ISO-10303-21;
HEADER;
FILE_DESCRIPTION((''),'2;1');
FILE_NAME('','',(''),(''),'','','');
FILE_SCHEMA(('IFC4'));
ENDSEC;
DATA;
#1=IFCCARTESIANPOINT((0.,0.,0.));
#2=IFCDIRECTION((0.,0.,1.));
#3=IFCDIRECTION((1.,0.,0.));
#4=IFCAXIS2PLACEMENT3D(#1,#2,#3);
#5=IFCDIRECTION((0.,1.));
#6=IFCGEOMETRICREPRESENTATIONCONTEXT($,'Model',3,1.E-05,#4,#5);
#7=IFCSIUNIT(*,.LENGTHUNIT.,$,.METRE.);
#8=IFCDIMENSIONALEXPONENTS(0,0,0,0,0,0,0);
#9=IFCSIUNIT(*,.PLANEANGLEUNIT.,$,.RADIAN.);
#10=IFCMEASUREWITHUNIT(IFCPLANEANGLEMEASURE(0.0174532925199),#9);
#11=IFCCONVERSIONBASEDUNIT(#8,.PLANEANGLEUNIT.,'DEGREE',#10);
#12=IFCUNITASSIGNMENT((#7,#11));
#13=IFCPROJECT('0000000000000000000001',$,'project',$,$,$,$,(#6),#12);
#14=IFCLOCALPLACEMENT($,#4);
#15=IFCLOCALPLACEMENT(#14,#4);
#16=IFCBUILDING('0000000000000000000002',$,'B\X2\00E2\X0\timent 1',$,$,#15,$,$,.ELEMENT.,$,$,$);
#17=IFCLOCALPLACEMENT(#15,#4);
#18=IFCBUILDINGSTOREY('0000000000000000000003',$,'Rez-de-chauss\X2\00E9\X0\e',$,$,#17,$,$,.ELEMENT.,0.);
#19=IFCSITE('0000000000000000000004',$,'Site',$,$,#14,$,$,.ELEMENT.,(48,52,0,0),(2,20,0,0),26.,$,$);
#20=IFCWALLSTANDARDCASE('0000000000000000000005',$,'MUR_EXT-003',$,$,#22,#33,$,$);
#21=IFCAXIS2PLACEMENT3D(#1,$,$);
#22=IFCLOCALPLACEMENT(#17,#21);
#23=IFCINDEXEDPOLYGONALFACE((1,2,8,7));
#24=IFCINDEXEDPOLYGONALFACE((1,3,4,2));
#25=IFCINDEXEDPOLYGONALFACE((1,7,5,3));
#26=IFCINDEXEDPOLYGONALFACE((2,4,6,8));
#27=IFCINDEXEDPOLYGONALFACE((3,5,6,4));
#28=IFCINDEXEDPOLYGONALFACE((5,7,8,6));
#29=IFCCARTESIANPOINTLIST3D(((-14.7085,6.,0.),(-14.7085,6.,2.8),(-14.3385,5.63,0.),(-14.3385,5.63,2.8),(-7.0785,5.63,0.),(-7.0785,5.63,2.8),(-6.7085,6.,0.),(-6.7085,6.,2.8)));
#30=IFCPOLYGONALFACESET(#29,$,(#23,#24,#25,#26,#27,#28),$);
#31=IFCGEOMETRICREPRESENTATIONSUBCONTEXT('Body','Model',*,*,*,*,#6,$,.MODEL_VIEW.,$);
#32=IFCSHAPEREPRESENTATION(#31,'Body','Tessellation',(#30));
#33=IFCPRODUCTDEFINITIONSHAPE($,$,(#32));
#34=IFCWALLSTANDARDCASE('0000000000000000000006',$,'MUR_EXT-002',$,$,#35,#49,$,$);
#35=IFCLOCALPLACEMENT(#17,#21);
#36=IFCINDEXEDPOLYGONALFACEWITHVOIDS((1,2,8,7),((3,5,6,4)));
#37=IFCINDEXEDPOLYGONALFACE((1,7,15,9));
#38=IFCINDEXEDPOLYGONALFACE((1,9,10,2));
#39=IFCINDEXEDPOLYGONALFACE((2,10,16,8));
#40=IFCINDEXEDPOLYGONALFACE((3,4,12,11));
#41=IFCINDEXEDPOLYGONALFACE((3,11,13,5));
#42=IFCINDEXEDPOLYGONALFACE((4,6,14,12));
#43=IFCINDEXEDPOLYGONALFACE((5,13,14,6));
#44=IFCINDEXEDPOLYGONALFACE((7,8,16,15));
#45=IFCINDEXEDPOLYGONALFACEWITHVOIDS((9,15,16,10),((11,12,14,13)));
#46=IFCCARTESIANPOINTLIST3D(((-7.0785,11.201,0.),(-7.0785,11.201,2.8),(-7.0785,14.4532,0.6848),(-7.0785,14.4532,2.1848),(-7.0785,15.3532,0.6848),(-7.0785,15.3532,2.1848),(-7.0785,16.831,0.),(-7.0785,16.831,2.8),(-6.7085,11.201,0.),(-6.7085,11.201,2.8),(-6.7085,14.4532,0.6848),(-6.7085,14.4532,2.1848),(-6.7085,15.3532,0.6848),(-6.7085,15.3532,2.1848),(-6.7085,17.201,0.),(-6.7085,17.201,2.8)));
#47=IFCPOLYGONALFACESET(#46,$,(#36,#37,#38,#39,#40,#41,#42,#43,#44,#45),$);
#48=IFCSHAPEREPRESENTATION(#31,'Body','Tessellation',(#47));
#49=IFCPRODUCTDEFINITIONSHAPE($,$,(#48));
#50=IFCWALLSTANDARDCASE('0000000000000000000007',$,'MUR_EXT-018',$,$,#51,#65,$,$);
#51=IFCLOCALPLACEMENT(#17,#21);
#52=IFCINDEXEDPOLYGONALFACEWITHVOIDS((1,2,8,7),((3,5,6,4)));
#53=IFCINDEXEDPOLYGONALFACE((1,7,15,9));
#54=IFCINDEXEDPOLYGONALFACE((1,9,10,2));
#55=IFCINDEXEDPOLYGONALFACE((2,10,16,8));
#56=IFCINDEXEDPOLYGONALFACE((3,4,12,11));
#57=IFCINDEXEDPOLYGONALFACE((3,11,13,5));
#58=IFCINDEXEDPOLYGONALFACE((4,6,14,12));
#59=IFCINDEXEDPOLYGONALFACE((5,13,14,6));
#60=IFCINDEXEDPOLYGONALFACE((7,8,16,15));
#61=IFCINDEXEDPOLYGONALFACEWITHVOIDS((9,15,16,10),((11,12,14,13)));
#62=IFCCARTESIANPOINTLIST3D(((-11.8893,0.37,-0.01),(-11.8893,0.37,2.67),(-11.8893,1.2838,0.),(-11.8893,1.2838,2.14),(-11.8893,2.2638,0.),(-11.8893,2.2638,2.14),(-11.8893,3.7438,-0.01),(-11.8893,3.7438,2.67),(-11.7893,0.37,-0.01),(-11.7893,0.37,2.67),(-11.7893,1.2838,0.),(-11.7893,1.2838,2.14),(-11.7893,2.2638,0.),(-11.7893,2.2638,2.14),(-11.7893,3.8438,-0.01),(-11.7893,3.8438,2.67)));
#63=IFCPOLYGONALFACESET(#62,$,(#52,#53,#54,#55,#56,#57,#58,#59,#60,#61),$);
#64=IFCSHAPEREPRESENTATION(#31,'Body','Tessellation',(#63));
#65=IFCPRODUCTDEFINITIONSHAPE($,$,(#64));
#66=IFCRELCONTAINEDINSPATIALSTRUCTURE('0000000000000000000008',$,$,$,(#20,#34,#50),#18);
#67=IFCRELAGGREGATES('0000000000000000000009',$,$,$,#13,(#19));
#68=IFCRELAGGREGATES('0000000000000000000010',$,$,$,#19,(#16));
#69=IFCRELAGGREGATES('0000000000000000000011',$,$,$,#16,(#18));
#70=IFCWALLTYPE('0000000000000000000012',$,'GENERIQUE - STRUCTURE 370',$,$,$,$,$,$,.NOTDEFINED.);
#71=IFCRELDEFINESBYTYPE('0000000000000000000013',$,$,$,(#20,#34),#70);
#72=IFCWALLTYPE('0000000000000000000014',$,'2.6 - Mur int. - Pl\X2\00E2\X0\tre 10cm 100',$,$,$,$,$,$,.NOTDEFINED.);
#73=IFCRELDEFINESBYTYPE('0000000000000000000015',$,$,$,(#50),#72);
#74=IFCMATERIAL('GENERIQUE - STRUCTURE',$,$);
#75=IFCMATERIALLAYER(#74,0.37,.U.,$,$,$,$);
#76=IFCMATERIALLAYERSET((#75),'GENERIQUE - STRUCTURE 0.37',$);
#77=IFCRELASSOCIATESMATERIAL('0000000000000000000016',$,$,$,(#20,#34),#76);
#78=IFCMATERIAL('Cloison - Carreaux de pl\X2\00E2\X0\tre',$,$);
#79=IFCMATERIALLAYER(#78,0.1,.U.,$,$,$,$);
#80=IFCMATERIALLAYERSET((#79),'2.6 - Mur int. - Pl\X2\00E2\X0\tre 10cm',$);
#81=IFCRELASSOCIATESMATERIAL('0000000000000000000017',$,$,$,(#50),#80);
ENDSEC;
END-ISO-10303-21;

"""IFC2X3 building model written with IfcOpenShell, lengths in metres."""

from ifc_helpers import new_model, entity, si_unit, converted_unit, direction, frame, origin_with_axes, origin_2d_with_axis, place, context, subcontext, project, spatial, polyline, rectangle, outline, extrude, material, layer, layer_set, layer_usage, type_object, element, save


model = new_model("IFC2X3")

# Units and contexts
model_context = context("Model", 3, precision=1e-05, world=origin_with_axes(), true_north=direction((0.0, 1.0)))
body_context = subcontext(model_context, "Body", "Model", "MODEL_VIEW")
ifc_project = project(units=[si_unit("LENGTHUNIT", "METRE"), converted_unit("PLANEANGLEUNIT", "DEGREE", entity("IfcPlaneAngleMeasure", 0.0174532925199), si_unit("PLANEANGLEUNIT", "RADIAN"), dimensions=[0, 0, 0, 0, 0, 0, 0])], contexts=[model_context])

# Site, building, storey
site_placement = place(None, origin_with_axes())
site = spatial("IfcSite", under=ifc_project, at=site_placement, Name="Site", CompositionType="ELEMENT", RefLatitude=(48, 52, 0, 0), RefLongitude=(2, 20, 0, 0), RefElevation=26.0)
building_placement = place(site_placement, origin_with_axes())
building = spatial("IfcBuilding", under=site, at=building_placement, Name="Bâtiment 1", CompositionType="ELEMENT")
storey_placement = place(building_placement, origin_with_axes())
storey = spatial("IfcBuildingStorey", under=building, at=storey_placement, Name="Rez-de-chaussée", CompositionType="ELEMENT", Elevation=0.0)

# Shared definitions
ifc_material_1 = material(Name="GENERIQUE - STRUCTURE")
ifc_layer_1 = layer(ifc_material_1, 0.37, ventilated="UNKNOWN")
ifc_layer_set_1 = layer_set([ifc_layer_1], Name="GENERIQUE - STRUCTURE 0.37")
wall_type_1 = type_object("IfcWallType", Name="GENERIQUE - STRUCTURE 370", PredefinedType="NOTDEFINED")

# Wall
ifc_layer_usage_1 = layer_usage(ifc_layer_set_1, "AXIS2", "POSITIVE", 0.0)
wall_1_placement = place(storey_placement, frame((-6.7085, 6.0, 0.0), z_axis=(0.0, 0.0, 1.0), x_axis=(-1.0, 0.0, 0.0)))
element("IfcWallStandardCase", 1, at=wall_1_placement, inside=storey, type_object=wall_type_1, material=ifc_layer_usage_1, Name="MUR_EXT-003", context=body_context, shape_type="SweptSolid", body=[
    extrude(outline(polyline([(0.0, 0.0), (8.0, 0.0), (7.63, 0.37), (0.37, 0.37), (0.0, 0.0)])), origin_with_axes(), (0.0, 0.0, 1.0), 2.8),
])

# Walls, openings
ifc_layer_usage_2 = layer_usage(ifc_layer_set_1, "AXIS2", "POSITIVE", 0.0)
wall_2_placement = place(storey_placement, frame((-6.7085, 11.201, 0.0), z_axis=(0.0, 0.0, 1.0), x_axis=(0.0, 1.0, 0.0)))
wall_2 = element("IfcWallStandardCase", 2, at=wall_2_placement, inside=storey, type_object=wall_type_1, material=ifc_layer_usage_2, Name="MUR_EXT-002", context=body_context, shape_type="SweptSolid", body=[
    extrude(outline(polyline([(0.0, 0.0), (6.0, 0.0), (5.63, 0.37), (0.0, 0.37), (0.0, 0.0)])), origin_with_axes(), (0.0, 0.0, 1.0), 2.8),
])
opening_1_placement = place(wall_2_placement, frame((3.7022, 0.0, 0.6848), z_axis=(0.0, 0.0, 1.0), x_axis=(1.0, 0.0, 0.0)))
element("IfcOpeningElement", 3, at=opening_1_placement, cuts=wall_2, context=body_context, shape_type="SweptSolid", body=[
    extrude(rectangle(XDim=0.9, YDim=1.5, at=origin_2d_with_axis()), frame((0.0, 0.37, 0.75), z_axis=(0.0, -1.0, 0.0), x_axis=(-1.0, 0.0, 0.0)), (0.0, 0.0, 1.0), 1.11),
])
ifc_material_2 = material(Name="Cloison - Carreaux de plâtre")
ifc_layer_2 = layer(ifc_material_2, 0.1, ventilated="UNKNOWN")
ifc_layer_set_2 = layer_set([ifc_layer_2], Name="2.6 - Mur int. - Plâtre 10cm")
ifc_layer_usage_3 = layer_usage(ifc_layer_set_2, "AXIS2", "POSITIVE", -0.05)
wall_type_2 = type_object("IfcWallType", Name="2.6 - Mur int. - Plâtre 10cm 100", PredefinedType="NOTDEFINED")
wall_3_placement = place(storey_placement, frame((-11.8393, 3.7938, -0.01), z_axis=(0.0, 0.0, 1.0), x_axis=(0.0, -1.0, 0.0)))
wall_3 = element("IfcWallStandardCase", 4, at=wall_3_placement, inside=storey, type_object=wall_type_2, material=ifc_layer_usage_3, Name="MUR_EXT-018", context=body_context, shape_type="SweptSolid", body=[
    extrude(outline(polyline([(0.05, -0.05), (3.4238, -0.05), (3.4238, 0.05), (-0.05, 0.05), (0.05, -0.05)])), origin_with_axes(), (0.0, 0.0, 1.0), 2.68),
])
opening_2_placement = place(wall_3_placement, frame((2.02, 0.0, 0.01), z_axis=(0.0, 0.0, 1.0), x_axis=(1.0, 0.0, 0.0)))
element("IfcOpeningElement", 5, at=opening_2_placement, cuts=wall_3, context=body_context, shape_type="SweptSolid", body=[
    extrude(rectangle(XDim=0.98, YDim=2.14, at=origin_2d_with_axis()), frame((0.0, -0.1, 1.07), z_axis=(0.0, -1.0, 0.0), x_axis=(-1.0, 0.0, 0.0)), (0.0, 0.0, -1.0), 0.3),
])

save(model, "model.ifc")
